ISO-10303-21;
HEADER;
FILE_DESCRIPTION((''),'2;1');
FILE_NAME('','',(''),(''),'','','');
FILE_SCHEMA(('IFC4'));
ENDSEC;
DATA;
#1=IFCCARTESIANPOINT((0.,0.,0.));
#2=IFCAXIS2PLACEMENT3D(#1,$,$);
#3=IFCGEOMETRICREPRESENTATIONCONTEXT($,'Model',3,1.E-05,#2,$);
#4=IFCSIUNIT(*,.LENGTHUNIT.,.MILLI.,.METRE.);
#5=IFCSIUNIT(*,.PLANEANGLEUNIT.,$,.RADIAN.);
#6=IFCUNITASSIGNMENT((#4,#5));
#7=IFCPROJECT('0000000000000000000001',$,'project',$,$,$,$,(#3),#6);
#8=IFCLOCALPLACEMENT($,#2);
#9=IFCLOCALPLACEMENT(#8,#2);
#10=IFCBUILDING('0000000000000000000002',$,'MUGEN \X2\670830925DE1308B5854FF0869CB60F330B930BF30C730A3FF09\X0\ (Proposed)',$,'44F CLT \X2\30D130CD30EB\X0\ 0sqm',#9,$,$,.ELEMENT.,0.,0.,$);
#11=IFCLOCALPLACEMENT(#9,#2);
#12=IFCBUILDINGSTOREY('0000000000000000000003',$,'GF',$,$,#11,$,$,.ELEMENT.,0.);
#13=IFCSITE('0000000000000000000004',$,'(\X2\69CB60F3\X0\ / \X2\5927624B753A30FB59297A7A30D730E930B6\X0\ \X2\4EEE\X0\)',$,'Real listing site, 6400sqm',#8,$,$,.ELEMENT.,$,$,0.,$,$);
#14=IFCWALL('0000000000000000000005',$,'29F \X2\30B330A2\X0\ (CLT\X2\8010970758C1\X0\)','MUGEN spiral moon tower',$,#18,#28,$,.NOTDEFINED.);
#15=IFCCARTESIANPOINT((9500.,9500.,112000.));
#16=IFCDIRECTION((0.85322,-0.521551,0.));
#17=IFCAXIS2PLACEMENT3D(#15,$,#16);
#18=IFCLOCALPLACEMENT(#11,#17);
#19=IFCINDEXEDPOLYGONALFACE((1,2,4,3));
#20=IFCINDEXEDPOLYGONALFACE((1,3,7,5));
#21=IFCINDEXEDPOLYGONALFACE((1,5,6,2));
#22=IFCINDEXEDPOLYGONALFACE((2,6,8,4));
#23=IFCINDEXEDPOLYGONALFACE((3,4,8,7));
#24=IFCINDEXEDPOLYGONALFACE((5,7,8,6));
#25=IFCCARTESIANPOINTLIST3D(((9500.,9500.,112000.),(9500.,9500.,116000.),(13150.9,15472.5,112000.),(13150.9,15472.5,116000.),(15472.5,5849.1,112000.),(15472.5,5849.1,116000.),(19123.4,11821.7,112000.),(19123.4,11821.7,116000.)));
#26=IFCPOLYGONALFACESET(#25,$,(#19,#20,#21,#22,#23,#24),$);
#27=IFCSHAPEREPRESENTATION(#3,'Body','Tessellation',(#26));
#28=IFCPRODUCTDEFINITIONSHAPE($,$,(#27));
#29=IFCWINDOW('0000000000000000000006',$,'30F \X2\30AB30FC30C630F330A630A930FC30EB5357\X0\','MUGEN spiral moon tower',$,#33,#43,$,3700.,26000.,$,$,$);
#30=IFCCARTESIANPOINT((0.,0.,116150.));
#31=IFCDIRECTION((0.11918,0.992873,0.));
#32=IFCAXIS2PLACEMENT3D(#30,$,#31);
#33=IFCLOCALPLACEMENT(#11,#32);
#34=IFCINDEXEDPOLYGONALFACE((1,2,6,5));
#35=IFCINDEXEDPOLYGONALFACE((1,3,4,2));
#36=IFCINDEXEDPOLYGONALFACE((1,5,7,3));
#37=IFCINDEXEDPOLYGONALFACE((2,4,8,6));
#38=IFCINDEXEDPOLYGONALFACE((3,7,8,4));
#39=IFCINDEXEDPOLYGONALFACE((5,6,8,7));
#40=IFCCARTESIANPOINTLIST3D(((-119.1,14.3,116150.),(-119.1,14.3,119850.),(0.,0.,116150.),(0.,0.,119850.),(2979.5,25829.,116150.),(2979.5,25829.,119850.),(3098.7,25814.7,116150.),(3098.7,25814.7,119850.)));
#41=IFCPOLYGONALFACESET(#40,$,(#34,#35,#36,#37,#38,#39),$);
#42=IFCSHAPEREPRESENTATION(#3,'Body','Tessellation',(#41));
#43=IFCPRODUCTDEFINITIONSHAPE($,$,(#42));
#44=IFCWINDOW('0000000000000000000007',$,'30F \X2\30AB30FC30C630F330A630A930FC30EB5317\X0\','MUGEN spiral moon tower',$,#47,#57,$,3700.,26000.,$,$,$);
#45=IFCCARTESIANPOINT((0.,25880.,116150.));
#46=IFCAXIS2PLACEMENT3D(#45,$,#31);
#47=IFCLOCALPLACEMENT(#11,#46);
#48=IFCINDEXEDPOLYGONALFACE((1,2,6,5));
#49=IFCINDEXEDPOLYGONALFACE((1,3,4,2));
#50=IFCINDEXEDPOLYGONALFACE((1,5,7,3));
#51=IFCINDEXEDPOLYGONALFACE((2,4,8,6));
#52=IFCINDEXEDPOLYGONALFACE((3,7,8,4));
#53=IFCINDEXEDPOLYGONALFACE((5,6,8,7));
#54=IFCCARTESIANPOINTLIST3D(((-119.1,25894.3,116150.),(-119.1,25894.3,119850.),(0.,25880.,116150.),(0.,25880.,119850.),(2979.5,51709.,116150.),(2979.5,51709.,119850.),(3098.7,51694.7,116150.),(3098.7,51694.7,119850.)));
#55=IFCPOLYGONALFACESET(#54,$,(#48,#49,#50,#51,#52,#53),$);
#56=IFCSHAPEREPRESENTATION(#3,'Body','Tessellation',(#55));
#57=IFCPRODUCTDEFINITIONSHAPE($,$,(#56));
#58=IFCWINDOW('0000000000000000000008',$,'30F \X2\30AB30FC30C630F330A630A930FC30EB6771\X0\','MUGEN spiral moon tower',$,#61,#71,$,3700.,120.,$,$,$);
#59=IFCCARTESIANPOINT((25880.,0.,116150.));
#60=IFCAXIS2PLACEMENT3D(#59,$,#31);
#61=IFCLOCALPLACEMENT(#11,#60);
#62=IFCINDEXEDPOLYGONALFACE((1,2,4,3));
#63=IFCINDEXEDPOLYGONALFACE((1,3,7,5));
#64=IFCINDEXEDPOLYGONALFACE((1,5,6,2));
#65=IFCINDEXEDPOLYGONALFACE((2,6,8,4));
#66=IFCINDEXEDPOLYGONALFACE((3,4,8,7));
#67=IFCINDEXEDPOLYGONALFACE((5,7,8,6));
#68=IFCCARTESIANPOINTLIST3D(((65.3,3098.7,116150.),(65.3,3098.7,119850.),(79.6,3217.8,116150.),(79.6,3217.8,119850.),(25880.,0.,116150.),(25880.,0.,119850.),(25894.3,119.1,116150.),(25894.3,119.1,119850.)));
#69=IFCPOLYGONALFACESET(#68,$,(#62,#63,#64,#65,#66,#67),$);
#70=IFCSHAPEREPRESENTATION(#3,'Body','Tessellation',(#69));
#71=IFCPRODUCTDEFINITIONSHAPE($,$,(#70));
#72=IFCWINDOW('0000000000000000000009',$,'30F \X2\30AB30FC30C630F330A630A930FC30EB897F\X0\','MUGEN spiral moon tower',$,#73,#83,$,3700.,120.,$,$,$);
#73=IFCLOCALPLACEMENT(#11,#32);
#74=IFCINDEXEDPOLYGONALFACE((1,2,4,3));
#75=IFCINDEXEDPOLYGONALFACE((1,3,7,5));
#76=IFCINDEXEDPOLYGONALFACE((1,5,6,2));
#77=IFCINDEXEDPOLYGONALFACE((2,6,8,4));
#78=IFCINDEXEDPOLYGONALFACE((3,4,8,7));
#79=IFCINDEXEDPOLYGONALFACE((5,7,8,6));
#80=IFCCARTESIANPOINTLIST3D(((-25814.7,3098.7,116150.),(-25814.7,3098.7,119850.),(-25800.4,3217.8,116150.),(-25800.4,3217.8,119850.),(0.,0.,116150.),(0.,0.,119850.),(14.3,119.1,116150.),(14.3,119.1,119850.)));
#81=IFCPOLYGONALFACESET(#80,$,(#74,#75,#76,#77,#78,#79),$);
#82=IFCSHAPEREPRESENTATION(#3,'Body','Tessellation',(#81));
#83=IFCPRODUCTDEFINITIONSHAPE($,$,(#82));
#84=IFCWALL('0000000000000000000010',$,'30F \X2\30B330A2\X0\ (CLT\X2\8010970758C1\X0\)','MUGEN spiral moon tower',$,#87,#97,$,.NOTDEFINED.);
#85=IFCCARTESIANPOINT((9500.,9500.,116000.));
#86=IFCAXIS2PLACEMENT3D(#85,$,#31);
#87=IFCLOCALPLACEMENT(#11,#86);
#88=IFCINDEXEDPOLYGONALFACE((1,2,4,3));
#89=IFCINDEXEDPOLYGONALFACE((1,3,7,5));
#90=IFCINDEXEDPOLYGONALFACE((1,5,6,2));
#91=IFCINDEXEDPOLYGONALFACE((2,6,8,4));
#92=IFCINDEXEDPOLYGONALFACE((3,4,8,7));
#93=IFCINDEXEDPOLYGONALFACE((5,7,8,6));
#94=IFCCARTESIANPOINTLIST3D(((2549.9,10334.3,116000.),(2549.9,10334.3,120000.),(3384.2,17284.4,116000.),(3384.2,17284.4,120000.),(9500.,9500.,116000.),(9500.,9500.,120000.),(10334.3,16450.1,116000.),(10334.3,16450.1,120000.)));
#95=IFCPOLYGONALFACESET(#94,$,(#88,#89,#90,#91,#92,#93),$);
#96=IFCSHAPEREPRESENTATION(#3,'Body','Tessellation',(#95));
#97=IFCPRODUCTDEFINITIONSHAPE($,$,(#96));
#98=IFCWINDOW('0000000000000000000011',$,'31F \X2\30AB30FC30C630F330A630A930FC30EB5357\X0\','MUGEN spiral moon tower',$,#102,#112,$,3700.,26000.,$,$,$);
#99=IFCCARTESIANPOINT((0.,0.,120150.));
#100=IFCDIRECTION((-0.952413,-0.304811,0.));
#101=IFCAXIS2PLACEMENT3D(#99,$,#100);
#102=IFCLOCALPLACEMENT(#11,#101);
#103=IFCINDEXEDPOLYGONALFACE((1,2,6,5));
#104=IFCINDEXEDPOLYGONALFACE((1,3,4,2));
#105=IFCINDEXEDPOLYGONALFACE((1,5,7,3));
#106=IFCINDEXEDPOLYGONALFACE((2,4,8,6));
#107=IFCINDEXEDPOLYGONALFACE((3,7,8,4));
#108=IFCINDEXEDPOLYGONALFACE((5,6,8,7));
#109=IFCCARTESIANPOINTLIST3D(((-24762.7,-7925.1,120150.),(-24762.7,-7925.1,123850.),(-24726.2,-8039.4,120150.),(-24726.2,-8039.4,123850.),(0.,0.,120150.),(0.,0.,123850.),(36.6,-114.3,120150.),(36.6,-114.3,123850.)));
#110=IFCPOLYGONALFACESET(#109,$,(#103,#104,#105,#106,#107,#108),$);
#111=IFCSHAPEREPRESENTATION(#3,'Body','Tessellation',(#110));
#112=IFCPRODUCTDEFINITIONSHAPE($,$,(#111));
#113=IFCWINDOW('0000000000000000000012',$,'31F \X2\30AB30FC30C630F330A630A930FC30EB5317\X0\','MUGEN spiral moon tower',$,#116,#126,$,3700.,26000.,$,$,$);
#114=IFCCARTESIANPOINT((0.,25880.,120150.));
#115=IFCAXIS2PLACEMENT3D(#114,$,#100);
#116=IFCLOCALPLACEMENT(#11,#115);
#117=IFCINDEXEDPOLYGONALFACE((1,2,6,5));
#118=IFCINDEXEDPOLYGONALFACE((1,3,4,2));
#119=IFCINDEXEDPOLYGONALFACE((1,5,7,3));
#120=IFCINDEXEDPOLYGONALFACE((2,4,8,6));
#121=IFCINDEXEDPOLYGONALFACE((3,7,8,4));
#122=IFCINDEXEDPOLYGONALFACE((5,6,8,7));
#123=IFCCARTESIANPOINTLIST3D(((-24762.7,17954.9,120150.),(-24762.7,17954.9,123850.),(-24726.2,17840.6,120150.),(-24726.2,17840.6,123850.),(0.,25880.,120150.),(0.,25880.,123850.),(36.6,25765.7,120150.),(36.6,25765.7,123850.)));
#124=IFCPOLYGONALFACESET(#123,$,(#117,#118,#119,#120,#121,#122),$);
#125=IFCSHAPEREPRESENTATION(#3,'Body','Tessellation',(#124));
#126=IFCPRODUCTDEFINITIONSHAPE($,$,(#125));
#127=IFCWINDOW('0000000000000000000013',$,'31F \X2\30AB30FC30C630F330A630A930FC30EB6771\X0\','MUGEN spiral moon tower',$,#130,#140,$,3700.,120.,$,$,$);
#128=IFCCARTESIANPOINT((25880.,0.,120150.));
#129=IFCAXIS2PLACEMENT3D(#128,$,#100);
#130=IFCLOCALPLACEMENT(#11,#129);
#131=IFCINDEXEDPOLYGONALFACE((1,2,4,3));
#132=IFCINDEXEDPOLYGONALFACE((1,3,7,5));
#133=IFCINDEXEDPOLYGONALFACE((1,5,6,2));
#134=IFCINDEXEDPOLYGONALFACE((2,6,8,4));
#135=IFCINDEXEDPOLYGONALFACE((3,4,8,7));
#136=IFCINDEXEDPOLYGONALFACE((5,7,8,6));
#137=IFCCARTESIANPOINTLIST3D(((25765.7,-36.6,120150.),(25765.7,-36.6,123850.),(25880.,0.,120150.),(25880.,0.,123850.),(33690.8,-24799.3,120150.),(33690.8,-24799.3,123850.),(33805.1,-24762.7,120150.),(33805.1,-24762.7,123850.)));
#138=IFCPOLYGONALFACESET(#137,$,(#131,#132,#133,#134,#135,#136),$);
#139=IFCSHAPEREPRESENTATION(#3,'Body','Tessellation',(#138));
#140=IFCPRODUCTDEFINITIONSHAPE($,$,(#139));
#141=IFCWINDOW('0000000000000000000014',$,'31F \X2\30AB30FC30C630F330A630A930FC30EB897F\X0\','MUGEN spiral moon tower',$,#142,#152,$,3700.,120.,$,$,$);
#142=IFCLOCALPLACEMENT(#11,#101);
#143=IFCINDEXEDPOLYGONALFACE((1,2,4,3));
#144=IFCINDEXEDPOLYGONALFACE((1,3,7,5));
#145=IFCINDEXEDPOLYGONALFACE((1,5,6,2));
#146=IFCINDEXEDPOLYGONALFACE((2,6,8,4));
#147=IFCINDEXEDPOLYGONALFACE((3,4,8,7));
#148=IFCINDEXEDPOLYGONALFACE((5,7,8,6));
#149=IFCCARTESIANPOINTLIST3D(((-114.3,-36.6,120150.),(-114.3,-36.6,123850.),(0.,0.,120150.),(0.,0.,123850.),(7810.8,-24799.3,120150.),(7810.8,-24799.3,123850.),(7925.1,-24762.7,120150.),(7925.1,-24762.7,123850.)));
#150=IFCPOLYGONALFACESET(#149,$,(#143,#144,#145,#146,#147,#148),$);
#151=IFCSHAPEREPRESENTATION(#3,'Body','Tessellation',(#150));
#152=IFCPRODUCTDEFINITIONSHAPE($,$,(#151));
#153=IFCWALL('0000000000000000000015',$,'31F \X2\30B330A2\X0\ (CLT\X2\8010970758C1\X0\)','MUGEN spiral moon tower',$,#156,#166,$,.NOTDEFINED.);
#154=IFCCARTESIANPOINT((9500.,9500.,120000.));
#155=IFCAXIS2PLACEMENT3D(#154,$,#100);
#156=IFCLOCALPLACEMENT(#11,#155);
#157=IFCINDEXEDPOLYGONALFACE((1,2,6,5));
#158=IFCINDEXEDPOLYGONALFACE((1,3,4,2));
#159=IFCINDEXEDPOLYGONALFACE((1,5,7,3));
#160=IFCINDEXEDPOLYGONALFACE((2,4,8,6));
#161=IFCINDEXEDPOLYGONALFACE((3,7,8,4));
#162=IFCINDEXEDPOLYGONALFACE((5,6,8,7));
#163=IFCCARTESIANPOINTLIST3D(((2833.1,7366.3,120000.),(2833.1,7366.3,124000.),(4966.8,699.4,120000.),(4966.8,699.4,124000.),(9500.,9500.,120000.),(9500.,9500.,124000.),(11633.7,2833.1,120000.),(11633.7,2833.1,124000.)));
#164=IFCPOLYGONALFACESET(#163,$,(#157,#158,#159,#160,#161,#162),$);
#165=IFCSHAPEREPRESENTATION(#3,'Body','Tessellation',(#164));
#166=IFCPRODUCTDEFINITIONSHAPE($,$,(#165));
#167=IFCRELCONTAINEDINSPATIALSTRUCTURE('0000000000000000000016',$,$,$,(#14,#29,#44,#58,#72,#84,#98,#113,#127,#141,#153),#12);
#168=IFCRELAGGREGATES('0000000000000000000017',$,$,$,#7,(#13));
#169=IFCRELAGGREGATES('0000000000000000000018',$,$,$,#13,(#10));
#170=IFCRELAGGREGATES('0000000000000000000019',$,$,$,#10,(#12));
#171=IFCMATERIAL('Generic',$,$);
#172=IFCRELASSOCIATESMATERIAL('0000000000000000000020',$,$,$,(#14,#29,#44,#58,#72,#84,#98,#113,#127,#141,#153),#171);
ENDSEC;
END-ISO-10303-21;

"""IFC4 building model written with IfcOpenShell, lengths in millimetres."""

from ifc_helpers import new_model, si_unit, frame, frame_2d, origin, place, context, project, spatial, rectangle, extrude, material, element, save


model = new_model("IFC4")

# Units and contexts
model_context = context("Model", 3, precision=1e-05, world=origin())
ifc_project = project(units=[si_unit("LENGTHUNIT", "METRE", prefix="MILLI"), si_unit("PLANEANGLEUNIT", "RADIAN")], contexts=[model_context])

# Site, building, storey
site_placement = place(None, origin())
site = spatial("IfcSite", under=ifc_project, at=site_placement, Name="(構想 / 大手町・天空プラザ 仮)", ObjectType="Real listing site, 6400sqm", CompositionType="ELEMENT", RefElevation=0.0)
building_placement = place(site_placement, origin())
building = spatial("IfcBuilding", under=site, at=building_placement, Name="MUGEN 月を巡る塔（構想スタディ） (Proposed)", ObjectType="44F CLT パネル 0sqm", CompositionType="ELEMENT", ElevationOfRefHeight=0.0, ElevationOfTerrain=0.0)
storey_placement = place(building_placement, origin())
storey = spatial("IfcBuildingStorey", under=building, at=storey_placement, Name="GF", CompositionType="ELEMENT", Elevation=0.0)

# Shared definitions
ifc_material = material(Name="Generic")

# Wall
wall_1_placement = place(storey_placement, frame((9500.0, 9500.0, 112000.0), x_axis=(0.85322, -0.521551, 0.0)))
element("IfcWall", 1, at=wall_1_placement, inside=storey, material=ifc_material, Name="29F コア (CLT耐震壁)", Description="MUGEN spiral moon tower", PredefinedType="NOTDEFINED", context=model_context, shape_type="SweptSolid", body=[
    extrude(rectangle(XDim=7000.0, YDim=7000.0, at=frame_2d((3500.0, 3500.0))), frame((9500.0, 9500.0, 112000.0), x_axis=(0.85322, -0.521551, 0.0)), (0.0, 0.0, 1.0), 4000.0),
])

# Windows
window_1_placement = place(storey_placement, frame((0.0, 0.0, 116150.0), x_axis=(0.11918, 0.992873, 0.0)))
element("IfcWindow", 2, at=window_1_placement, inside=storey, material=ifc_material, Name="30F カーテンウォール南", Description="MUGEN spiral moon tower", OverallHeight=3700.0, OverallWidth=26000.0, context=model_context, shape_type="SweptSolid", body=[
    extrude(rectangle(XDim=26000.0, YDim=120.0, at=frame_2d((13000.0, 60.0))), frame((0.0, 0.0, 116150.0), x_axis=(0.11918, 0.992873, 0.0)), (0.0, 0.0, 1.0), 3700.0),
])
window_2_placement = place(storey_placement, frame((0.0, 25880.0, 116150.0), x_axis=(0.11918, 0.992873, 0.0)))
element("IfcWindow", 3, at=window_2_placement, inside=storey, material=ifc_material, Name="30F カーテンウォール北", Description="MUGEN spiral moon tower", OverallHeight=3700.0, OverallWidth=26000.0, context=model_context, shape_type="SweptSolid", body=[
    extrude(rectangle(XDim=26000.0, YDim=120.0, at=frame_2d((13000.0, 60.0))), frame((0.0, 25880.0, 116150.0), x_axis=(0.11918, 0.992873, 0.0)), (0.0, 0.0, 1.0), 3700.0),
])
window_3_placement = place(storey_placement, frame((25880.0, 0.0, 116150.0), x_axis=(0.11918, 0.992873, 0.0)))
element("IfcWindow", 4, at=window_3_placement, inside=storey, material=ifc_material, Name="30F カーテンウォール東", Description="MUGEN spiral moon tower", OverallHeight=3700.0, OverallWidth=120.0, context=model_context, shape_type="SweptSolid", body=[
    extrude(rectangle(XDim=120.0, YDim=26000.0, at=frame_2d((60.0, 13000.0))), frame((25880.0, 0.0, 116150.0), x_axis=(0.11918, 0.992873, 0.0)), (0.0, 0.0, 1.0), 3700.0),
])
window_4_placement = place(storey_placement, frame((0.0, 0.0, 116150.0), x_axis=(0.11918, 0.992873, 0.0)))
element("IfcWindow", 5, at=window_4_placement, inside=storey, material=ifc_material, Name="30F カーテンウォール西", Description="MUGEN spiral moon tower", OverallHeight=3700.0, OverallWidth=120.0, context=model_context, shape_type="SweptSolid", body=[
    extrude(rectangle(XDim=120.0, YDim=26000.0, at=frame_2d((60.0, 13000.0))), frame((0.0, 0.0, 116150.0), x_axis=(0.11918, 0.992873, 0.0)), (0.0, 0.0, 1.0), 3700.0),
])

# Wall
wall_2_placement = place(storey_placement, frame((9500.0, 9500.0, 116000.0), x_axis=(0.11918, 0.992873, 0.0)))
element("IfcWall", 6, at=wall_2_placement, inside=storey, material=ifc_material, Name="30F コア (CLT耐震壁)", Description="MUGEN spiral moon tower", PredefinedType="NOTDEFINED", context=model_context, shape_type="SweptSolid", body=[
    extrude(rectangle(XDim=7000.0, YDim=7000.0, at=frame_2d((3500.0, 3500.0))), frame((9500.0, 9500.0, 116000.0), x_axis=(0.11918, 0.992873, 0.0)), (0.0, 0.0, 1.0), 4000.0),
])

# Windows
window_5_placement = place(storey_placement, frame((0.0, 0.0, 120150.0), x_axis=(-0.952413, -0.304811, 0.0)))
element("IfcWindow", 7, at=window_5_placement, inside=storey, material=ifc_material, Name="31F カーテンウォール南", Description="MUGEN spiral moon tower", OverallHeight=3700.0, OverallWidth=26000.0, context=model_context, shape_type="SweptSolid", body=[
    extrude(rectangle(XDim=26000.0, YDim=120.0, at=frame_2d((13000.0, 60.0))), frame((0.0, 0.0, 120150.0), x_axis=(-0.952413, -0.304811, 0.0)), (0.0, 0.0, 1.0), 3700.0),
])
window_6_placement = place(storey_placement, frame((0.0, 25880.0, 120150.0), x_axis=(-0.952413, -0.304811, 0.0)))
element("IfcWindow", 8, at=window_6_placement, inside=storey, material=ifc_material, Name="31F カーテンウォール北", Description="MUGEN spiral moon tower", OverallHeight=3700.0, OverallWidth=26000.0, context=model_context, shape_type="SweptSolid", body=[
    extrude(rectangle(XDim=26000.0, YDim=120.0, at=frame_2d((13000.0, 60.0))), frame((0.0, 25880.0, 120150.0), x_axis=(-0.952413, -0.304811, 0.0)), (0.0, 0.0, 1.0), 3700.0),
])
window_7_placement = place(storey_placement, frame((25880.0, 0.0, 120150.0), x_axis=(-0.952413, -0.304811, 0.0)))
element("IfcWindow", 9, at=window_7_placement, inside=storey, material=ifc_material, Name="31F カーテンウォール東", Description="MUGEN spiral moon tower", OverallHeight=3700.0, OverallWidth=120.0, context=model_context, shape_type="SweptSolid", body=[
    extrude(rectangle(XDim=120.0, YDim=26000.0, at=frame_2d((60.0, 13000.0))), frame((25880.0, 0.0, 120150.0), x_axis=(-0.952413, -0.304811, 0.0)), (0.0, 0.0, 1.0), 3700.0),
])
window_8_placement = place(storey_placement, frame((0.0, 0.0, 120150.0), x_axis=(-0.952413, -0.304811, 0.0)))
element("IfcWindow", 10, at=window_8_placement, inside=storey, material=ifc_material, Name="31F カーテンウォール西", Description="MUGEN spiral moon tower", OverallHeight=3700.0, OverallWidth=120.0, context=model_context, shape_type="SweptSolid", body=[
    extrude(rectangle(XDim=120.0, YDim=26000.0, at=frame_2d((60.0, 13000.0))), frame((0.0, 0.0, 120150.0), x_axis=(-0.952413, -0.304811, 0.0)), (0.0, 0.0, 1.0), 3700.0),
])

# Wall
wall_3_placement = place(storey_placement, frame((9500.0, 9500.0, 120000.0), x_axis=(-0.952413, -0.304811, 0.0)))
element("IfcWall", 11, at=wall_3_placement, inside=storey, material=ifc_material, Name="31F コア (CLT耐震壁)", Description="MUGEN spiral moon tower", PredefinedType="NOTDEFINED", context=model_context, shape_type="SweptSolid", body=[
    extrude(rectangle(XDim=7000.0, YDim=7000.0, at=frame_2d((3500.0, 3500.0))), frame((9500.0, 9500.0, 120000.0), x_axis=(-0.952413, -0.304811, 0.0)), (0.0, 0.0, 1.0), 4000.0),
])

save(model, "model.ifc")
